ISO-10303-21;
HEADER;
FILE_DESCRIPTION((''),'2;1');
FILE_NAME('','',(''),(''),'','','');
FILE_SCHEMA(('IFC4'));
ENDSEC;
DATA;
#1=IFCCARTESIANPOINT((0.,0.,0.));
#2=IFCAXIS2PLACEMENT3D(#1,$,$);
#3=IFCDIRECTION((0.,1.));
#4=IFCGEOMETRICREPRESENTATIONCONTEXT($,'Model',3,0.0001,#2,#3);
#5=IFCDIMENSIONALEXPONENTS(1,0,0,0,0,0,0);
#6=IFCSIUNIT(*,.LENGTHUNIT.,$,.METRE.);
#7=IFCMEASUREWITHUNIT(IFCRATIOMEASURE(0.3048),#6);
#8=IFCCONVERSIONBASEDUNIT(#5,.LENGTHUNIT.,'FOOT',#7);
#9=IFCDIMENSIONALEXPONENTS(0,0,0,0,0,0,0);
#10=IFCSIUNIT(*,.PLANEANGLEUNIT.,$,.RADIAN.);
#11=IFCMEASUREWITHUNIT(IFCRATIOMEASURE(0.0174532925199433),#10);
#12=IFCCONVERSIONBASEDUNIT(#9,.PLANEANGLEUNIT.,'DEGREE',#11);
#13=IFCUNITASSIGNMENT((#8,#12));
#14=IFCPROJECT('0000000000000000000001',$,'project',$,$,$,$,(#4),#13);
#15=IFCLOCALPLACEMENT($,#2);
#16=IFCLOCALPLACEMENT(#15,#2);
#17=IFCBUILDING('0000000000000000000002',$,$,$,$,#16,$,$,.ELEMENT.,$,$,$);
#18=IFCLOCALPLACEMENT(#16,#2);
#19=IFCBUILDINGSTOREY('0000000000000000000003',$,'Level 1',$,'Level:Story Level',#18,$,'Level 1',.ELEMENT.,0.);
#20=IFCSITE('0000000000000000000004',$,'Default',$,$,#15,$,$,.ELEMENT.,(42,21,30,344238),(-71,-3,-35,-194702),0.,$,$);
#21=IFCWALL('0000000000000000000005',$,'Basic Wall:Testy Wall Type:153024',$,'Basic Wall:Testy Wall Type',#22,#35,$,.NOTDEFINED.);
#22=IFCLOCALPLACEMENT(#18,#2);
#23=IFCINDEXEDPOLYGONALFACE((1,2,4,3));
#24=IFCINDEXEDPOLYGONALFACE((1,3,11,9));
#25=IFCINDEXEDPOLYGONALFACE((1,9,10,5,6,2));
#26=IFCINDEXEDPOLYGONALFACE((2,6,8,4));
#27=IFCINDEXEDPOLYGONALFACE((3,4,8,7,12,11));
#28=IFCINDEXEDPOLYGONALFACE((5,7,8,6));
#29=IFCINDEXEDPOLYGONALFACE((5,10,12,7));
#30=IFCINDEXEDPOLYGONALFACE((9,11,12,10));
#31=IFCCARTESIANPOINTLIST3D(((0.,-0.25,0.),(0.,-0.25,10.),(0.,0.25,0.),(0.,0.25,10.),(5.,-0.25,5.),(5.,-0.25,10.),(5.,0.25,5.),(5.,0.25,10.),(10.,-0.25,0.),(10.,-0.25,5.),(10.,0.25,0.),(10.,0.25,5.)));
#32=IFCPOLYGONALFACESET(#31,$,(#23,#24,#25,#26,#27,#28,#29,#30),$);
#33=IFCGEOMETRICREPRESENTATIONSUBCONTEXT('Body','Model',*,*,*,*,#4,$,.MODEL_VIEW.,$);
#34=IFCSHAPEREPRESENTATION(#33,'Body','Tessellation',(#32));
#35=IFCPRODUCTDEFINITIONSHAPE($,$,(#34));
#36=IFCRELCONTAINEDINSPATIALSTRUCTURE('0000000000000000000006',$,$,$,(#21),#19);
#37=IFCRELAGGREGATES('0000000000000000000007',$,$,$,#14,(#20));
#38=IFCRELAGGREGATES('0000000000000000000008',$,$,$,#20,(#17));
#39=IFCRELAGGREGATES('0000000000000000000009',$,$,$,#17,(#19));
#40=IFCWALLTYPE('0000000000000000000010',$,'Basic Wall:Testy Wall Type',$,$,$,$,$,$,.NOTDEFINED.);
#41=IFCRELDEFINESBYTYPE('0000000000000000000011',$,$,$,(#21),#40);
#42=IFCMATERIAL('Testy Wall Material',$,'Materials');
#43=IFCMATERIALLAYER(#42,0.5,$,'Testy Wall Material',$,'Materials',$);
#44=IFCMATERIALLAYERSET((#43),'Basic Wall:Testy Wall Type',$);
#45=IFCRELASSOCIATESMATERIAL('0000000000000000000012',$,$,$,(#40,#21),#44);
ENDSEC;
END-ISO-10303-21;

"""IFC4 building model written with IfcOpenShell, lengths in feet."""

from ifc_helpers import new_model, entity, si_unit, converted_unit, direction, frame, frame_2d, origin, origin_with_axes, place, context, subcontext, project, spatial, rectangle, extrude, material, layer, layer_set, layer_usage, type_object, element, save


model = new_model("IFC4")

# Units and contexts
model_context = context("Model", 3, precision=0.0001, world=origin(), true_north=direction((0.0, 1.0)))
body_context = subcontext(model_context, "Body", "Model", "MODEL_VIEW")
ifc_project = project(units=[converted_unit("LENGTHUNIT", "FOOT", entity("IfcRatioMeasure", 0.3048), si_unit("LENGTHUNIT", "METRE"), dimensions=[1, 0, 0, 0, 0, 0, 0]), converted_unit("PLANEANGLEUNIT", "DEGREE", entity("IfcRatioMeasure", 0.0174532925199433), si_unit("PLANEANGLEUNIT", "RADIAN"), dimensions=[0, 0, 0, 0, 0, 0, 0])], contexts=[model_context])

# Site, building, storey
site_placement = place(None, origin())
site = spatial("IfcSite", under=ifc_project, at=site_placement, Name="Default", CompositionType="ELEMENT", RefLatitude=(42, 21, 30, 344238), RefLongitude=(-71, -3, -35, -194702), RefElevation=0.0)
building_placement = place(site_placement, origin())
building = spatial("IfcBuilding", under=site, at=building_placement, CompositionType="ELEMENT")
storey_placement = place(building_placement, origin())
storey = spatial("IfcBuildingStorey", under=building, at=storey_placement, Name="Level 1", ObjectType="Level:Story Level", LongName="Level 1", CompositionType="ELEMENT", Elevation=0.0)

# Wall, opening
ifc_material = material(Name="Testy Wall Material", Category="Materials")
ifc_layer = layer(ifc_material, 0.5, Name="Testy Wall Material", Category="Materials")
ifc_layer_set = layer_set([ifc_layer], Name="Basic Wall:Testy Wall Type")
ifc_layer_usage = layer_usage(ifc_layer_set, "AXIS2", "NEGATIVE", 0.25)
wall_type = type_object("IfcWallType", Name="Basic Wall:Testy Wall Type", PredefinedType="NOTDEFINED", material=ifc_layer_set)
wall_placement = place(storey_placement, origin_with_axes())
wall = element("IfcWall", 1, at=wall_placement, inside=storey, type_object=wall_type, material=ifc_layer_usage, Name="Basic Wall:Testy Wall Type:153024", ObjectType="Basic Wall:Testy Wall Type", PredefinedType="NOTDEFINED", context=body_context, shape_type="SweptSolid", body=[
    extrude(rectangle(XDim=10.0, YDim=0.5), frame((5.0, 0.0, 0.0), z_axis=(0.0, 0.0, -1.0), x_axis=(-1.0, 0.0, 0.0)), (0.0, 0.0, -1.0), 10.0),
])
opening_placement = place(wall_placement, origin_with_axes())
element("IfcOpeningElement", 2, at=opening_placement, cuts=wall, ObjectType="Opening", PredefinedType="OPENING", context=body_context, shape_type="SweptSolid", body=[
    extrude(rectangle(XDim=5.0, YDim=5.0, at=frame_2d((0.0, 0.0), x_axis=(1.0, 0.0))), frame((7.5, 0.25, 7.5), z_axis=(0.0, -1.0, 0.0), x_axis=(0.0, 0.0, 1.0)), (0.0, 0.0, 1.0), 0.5),
])

save(model, "model.ifc")
